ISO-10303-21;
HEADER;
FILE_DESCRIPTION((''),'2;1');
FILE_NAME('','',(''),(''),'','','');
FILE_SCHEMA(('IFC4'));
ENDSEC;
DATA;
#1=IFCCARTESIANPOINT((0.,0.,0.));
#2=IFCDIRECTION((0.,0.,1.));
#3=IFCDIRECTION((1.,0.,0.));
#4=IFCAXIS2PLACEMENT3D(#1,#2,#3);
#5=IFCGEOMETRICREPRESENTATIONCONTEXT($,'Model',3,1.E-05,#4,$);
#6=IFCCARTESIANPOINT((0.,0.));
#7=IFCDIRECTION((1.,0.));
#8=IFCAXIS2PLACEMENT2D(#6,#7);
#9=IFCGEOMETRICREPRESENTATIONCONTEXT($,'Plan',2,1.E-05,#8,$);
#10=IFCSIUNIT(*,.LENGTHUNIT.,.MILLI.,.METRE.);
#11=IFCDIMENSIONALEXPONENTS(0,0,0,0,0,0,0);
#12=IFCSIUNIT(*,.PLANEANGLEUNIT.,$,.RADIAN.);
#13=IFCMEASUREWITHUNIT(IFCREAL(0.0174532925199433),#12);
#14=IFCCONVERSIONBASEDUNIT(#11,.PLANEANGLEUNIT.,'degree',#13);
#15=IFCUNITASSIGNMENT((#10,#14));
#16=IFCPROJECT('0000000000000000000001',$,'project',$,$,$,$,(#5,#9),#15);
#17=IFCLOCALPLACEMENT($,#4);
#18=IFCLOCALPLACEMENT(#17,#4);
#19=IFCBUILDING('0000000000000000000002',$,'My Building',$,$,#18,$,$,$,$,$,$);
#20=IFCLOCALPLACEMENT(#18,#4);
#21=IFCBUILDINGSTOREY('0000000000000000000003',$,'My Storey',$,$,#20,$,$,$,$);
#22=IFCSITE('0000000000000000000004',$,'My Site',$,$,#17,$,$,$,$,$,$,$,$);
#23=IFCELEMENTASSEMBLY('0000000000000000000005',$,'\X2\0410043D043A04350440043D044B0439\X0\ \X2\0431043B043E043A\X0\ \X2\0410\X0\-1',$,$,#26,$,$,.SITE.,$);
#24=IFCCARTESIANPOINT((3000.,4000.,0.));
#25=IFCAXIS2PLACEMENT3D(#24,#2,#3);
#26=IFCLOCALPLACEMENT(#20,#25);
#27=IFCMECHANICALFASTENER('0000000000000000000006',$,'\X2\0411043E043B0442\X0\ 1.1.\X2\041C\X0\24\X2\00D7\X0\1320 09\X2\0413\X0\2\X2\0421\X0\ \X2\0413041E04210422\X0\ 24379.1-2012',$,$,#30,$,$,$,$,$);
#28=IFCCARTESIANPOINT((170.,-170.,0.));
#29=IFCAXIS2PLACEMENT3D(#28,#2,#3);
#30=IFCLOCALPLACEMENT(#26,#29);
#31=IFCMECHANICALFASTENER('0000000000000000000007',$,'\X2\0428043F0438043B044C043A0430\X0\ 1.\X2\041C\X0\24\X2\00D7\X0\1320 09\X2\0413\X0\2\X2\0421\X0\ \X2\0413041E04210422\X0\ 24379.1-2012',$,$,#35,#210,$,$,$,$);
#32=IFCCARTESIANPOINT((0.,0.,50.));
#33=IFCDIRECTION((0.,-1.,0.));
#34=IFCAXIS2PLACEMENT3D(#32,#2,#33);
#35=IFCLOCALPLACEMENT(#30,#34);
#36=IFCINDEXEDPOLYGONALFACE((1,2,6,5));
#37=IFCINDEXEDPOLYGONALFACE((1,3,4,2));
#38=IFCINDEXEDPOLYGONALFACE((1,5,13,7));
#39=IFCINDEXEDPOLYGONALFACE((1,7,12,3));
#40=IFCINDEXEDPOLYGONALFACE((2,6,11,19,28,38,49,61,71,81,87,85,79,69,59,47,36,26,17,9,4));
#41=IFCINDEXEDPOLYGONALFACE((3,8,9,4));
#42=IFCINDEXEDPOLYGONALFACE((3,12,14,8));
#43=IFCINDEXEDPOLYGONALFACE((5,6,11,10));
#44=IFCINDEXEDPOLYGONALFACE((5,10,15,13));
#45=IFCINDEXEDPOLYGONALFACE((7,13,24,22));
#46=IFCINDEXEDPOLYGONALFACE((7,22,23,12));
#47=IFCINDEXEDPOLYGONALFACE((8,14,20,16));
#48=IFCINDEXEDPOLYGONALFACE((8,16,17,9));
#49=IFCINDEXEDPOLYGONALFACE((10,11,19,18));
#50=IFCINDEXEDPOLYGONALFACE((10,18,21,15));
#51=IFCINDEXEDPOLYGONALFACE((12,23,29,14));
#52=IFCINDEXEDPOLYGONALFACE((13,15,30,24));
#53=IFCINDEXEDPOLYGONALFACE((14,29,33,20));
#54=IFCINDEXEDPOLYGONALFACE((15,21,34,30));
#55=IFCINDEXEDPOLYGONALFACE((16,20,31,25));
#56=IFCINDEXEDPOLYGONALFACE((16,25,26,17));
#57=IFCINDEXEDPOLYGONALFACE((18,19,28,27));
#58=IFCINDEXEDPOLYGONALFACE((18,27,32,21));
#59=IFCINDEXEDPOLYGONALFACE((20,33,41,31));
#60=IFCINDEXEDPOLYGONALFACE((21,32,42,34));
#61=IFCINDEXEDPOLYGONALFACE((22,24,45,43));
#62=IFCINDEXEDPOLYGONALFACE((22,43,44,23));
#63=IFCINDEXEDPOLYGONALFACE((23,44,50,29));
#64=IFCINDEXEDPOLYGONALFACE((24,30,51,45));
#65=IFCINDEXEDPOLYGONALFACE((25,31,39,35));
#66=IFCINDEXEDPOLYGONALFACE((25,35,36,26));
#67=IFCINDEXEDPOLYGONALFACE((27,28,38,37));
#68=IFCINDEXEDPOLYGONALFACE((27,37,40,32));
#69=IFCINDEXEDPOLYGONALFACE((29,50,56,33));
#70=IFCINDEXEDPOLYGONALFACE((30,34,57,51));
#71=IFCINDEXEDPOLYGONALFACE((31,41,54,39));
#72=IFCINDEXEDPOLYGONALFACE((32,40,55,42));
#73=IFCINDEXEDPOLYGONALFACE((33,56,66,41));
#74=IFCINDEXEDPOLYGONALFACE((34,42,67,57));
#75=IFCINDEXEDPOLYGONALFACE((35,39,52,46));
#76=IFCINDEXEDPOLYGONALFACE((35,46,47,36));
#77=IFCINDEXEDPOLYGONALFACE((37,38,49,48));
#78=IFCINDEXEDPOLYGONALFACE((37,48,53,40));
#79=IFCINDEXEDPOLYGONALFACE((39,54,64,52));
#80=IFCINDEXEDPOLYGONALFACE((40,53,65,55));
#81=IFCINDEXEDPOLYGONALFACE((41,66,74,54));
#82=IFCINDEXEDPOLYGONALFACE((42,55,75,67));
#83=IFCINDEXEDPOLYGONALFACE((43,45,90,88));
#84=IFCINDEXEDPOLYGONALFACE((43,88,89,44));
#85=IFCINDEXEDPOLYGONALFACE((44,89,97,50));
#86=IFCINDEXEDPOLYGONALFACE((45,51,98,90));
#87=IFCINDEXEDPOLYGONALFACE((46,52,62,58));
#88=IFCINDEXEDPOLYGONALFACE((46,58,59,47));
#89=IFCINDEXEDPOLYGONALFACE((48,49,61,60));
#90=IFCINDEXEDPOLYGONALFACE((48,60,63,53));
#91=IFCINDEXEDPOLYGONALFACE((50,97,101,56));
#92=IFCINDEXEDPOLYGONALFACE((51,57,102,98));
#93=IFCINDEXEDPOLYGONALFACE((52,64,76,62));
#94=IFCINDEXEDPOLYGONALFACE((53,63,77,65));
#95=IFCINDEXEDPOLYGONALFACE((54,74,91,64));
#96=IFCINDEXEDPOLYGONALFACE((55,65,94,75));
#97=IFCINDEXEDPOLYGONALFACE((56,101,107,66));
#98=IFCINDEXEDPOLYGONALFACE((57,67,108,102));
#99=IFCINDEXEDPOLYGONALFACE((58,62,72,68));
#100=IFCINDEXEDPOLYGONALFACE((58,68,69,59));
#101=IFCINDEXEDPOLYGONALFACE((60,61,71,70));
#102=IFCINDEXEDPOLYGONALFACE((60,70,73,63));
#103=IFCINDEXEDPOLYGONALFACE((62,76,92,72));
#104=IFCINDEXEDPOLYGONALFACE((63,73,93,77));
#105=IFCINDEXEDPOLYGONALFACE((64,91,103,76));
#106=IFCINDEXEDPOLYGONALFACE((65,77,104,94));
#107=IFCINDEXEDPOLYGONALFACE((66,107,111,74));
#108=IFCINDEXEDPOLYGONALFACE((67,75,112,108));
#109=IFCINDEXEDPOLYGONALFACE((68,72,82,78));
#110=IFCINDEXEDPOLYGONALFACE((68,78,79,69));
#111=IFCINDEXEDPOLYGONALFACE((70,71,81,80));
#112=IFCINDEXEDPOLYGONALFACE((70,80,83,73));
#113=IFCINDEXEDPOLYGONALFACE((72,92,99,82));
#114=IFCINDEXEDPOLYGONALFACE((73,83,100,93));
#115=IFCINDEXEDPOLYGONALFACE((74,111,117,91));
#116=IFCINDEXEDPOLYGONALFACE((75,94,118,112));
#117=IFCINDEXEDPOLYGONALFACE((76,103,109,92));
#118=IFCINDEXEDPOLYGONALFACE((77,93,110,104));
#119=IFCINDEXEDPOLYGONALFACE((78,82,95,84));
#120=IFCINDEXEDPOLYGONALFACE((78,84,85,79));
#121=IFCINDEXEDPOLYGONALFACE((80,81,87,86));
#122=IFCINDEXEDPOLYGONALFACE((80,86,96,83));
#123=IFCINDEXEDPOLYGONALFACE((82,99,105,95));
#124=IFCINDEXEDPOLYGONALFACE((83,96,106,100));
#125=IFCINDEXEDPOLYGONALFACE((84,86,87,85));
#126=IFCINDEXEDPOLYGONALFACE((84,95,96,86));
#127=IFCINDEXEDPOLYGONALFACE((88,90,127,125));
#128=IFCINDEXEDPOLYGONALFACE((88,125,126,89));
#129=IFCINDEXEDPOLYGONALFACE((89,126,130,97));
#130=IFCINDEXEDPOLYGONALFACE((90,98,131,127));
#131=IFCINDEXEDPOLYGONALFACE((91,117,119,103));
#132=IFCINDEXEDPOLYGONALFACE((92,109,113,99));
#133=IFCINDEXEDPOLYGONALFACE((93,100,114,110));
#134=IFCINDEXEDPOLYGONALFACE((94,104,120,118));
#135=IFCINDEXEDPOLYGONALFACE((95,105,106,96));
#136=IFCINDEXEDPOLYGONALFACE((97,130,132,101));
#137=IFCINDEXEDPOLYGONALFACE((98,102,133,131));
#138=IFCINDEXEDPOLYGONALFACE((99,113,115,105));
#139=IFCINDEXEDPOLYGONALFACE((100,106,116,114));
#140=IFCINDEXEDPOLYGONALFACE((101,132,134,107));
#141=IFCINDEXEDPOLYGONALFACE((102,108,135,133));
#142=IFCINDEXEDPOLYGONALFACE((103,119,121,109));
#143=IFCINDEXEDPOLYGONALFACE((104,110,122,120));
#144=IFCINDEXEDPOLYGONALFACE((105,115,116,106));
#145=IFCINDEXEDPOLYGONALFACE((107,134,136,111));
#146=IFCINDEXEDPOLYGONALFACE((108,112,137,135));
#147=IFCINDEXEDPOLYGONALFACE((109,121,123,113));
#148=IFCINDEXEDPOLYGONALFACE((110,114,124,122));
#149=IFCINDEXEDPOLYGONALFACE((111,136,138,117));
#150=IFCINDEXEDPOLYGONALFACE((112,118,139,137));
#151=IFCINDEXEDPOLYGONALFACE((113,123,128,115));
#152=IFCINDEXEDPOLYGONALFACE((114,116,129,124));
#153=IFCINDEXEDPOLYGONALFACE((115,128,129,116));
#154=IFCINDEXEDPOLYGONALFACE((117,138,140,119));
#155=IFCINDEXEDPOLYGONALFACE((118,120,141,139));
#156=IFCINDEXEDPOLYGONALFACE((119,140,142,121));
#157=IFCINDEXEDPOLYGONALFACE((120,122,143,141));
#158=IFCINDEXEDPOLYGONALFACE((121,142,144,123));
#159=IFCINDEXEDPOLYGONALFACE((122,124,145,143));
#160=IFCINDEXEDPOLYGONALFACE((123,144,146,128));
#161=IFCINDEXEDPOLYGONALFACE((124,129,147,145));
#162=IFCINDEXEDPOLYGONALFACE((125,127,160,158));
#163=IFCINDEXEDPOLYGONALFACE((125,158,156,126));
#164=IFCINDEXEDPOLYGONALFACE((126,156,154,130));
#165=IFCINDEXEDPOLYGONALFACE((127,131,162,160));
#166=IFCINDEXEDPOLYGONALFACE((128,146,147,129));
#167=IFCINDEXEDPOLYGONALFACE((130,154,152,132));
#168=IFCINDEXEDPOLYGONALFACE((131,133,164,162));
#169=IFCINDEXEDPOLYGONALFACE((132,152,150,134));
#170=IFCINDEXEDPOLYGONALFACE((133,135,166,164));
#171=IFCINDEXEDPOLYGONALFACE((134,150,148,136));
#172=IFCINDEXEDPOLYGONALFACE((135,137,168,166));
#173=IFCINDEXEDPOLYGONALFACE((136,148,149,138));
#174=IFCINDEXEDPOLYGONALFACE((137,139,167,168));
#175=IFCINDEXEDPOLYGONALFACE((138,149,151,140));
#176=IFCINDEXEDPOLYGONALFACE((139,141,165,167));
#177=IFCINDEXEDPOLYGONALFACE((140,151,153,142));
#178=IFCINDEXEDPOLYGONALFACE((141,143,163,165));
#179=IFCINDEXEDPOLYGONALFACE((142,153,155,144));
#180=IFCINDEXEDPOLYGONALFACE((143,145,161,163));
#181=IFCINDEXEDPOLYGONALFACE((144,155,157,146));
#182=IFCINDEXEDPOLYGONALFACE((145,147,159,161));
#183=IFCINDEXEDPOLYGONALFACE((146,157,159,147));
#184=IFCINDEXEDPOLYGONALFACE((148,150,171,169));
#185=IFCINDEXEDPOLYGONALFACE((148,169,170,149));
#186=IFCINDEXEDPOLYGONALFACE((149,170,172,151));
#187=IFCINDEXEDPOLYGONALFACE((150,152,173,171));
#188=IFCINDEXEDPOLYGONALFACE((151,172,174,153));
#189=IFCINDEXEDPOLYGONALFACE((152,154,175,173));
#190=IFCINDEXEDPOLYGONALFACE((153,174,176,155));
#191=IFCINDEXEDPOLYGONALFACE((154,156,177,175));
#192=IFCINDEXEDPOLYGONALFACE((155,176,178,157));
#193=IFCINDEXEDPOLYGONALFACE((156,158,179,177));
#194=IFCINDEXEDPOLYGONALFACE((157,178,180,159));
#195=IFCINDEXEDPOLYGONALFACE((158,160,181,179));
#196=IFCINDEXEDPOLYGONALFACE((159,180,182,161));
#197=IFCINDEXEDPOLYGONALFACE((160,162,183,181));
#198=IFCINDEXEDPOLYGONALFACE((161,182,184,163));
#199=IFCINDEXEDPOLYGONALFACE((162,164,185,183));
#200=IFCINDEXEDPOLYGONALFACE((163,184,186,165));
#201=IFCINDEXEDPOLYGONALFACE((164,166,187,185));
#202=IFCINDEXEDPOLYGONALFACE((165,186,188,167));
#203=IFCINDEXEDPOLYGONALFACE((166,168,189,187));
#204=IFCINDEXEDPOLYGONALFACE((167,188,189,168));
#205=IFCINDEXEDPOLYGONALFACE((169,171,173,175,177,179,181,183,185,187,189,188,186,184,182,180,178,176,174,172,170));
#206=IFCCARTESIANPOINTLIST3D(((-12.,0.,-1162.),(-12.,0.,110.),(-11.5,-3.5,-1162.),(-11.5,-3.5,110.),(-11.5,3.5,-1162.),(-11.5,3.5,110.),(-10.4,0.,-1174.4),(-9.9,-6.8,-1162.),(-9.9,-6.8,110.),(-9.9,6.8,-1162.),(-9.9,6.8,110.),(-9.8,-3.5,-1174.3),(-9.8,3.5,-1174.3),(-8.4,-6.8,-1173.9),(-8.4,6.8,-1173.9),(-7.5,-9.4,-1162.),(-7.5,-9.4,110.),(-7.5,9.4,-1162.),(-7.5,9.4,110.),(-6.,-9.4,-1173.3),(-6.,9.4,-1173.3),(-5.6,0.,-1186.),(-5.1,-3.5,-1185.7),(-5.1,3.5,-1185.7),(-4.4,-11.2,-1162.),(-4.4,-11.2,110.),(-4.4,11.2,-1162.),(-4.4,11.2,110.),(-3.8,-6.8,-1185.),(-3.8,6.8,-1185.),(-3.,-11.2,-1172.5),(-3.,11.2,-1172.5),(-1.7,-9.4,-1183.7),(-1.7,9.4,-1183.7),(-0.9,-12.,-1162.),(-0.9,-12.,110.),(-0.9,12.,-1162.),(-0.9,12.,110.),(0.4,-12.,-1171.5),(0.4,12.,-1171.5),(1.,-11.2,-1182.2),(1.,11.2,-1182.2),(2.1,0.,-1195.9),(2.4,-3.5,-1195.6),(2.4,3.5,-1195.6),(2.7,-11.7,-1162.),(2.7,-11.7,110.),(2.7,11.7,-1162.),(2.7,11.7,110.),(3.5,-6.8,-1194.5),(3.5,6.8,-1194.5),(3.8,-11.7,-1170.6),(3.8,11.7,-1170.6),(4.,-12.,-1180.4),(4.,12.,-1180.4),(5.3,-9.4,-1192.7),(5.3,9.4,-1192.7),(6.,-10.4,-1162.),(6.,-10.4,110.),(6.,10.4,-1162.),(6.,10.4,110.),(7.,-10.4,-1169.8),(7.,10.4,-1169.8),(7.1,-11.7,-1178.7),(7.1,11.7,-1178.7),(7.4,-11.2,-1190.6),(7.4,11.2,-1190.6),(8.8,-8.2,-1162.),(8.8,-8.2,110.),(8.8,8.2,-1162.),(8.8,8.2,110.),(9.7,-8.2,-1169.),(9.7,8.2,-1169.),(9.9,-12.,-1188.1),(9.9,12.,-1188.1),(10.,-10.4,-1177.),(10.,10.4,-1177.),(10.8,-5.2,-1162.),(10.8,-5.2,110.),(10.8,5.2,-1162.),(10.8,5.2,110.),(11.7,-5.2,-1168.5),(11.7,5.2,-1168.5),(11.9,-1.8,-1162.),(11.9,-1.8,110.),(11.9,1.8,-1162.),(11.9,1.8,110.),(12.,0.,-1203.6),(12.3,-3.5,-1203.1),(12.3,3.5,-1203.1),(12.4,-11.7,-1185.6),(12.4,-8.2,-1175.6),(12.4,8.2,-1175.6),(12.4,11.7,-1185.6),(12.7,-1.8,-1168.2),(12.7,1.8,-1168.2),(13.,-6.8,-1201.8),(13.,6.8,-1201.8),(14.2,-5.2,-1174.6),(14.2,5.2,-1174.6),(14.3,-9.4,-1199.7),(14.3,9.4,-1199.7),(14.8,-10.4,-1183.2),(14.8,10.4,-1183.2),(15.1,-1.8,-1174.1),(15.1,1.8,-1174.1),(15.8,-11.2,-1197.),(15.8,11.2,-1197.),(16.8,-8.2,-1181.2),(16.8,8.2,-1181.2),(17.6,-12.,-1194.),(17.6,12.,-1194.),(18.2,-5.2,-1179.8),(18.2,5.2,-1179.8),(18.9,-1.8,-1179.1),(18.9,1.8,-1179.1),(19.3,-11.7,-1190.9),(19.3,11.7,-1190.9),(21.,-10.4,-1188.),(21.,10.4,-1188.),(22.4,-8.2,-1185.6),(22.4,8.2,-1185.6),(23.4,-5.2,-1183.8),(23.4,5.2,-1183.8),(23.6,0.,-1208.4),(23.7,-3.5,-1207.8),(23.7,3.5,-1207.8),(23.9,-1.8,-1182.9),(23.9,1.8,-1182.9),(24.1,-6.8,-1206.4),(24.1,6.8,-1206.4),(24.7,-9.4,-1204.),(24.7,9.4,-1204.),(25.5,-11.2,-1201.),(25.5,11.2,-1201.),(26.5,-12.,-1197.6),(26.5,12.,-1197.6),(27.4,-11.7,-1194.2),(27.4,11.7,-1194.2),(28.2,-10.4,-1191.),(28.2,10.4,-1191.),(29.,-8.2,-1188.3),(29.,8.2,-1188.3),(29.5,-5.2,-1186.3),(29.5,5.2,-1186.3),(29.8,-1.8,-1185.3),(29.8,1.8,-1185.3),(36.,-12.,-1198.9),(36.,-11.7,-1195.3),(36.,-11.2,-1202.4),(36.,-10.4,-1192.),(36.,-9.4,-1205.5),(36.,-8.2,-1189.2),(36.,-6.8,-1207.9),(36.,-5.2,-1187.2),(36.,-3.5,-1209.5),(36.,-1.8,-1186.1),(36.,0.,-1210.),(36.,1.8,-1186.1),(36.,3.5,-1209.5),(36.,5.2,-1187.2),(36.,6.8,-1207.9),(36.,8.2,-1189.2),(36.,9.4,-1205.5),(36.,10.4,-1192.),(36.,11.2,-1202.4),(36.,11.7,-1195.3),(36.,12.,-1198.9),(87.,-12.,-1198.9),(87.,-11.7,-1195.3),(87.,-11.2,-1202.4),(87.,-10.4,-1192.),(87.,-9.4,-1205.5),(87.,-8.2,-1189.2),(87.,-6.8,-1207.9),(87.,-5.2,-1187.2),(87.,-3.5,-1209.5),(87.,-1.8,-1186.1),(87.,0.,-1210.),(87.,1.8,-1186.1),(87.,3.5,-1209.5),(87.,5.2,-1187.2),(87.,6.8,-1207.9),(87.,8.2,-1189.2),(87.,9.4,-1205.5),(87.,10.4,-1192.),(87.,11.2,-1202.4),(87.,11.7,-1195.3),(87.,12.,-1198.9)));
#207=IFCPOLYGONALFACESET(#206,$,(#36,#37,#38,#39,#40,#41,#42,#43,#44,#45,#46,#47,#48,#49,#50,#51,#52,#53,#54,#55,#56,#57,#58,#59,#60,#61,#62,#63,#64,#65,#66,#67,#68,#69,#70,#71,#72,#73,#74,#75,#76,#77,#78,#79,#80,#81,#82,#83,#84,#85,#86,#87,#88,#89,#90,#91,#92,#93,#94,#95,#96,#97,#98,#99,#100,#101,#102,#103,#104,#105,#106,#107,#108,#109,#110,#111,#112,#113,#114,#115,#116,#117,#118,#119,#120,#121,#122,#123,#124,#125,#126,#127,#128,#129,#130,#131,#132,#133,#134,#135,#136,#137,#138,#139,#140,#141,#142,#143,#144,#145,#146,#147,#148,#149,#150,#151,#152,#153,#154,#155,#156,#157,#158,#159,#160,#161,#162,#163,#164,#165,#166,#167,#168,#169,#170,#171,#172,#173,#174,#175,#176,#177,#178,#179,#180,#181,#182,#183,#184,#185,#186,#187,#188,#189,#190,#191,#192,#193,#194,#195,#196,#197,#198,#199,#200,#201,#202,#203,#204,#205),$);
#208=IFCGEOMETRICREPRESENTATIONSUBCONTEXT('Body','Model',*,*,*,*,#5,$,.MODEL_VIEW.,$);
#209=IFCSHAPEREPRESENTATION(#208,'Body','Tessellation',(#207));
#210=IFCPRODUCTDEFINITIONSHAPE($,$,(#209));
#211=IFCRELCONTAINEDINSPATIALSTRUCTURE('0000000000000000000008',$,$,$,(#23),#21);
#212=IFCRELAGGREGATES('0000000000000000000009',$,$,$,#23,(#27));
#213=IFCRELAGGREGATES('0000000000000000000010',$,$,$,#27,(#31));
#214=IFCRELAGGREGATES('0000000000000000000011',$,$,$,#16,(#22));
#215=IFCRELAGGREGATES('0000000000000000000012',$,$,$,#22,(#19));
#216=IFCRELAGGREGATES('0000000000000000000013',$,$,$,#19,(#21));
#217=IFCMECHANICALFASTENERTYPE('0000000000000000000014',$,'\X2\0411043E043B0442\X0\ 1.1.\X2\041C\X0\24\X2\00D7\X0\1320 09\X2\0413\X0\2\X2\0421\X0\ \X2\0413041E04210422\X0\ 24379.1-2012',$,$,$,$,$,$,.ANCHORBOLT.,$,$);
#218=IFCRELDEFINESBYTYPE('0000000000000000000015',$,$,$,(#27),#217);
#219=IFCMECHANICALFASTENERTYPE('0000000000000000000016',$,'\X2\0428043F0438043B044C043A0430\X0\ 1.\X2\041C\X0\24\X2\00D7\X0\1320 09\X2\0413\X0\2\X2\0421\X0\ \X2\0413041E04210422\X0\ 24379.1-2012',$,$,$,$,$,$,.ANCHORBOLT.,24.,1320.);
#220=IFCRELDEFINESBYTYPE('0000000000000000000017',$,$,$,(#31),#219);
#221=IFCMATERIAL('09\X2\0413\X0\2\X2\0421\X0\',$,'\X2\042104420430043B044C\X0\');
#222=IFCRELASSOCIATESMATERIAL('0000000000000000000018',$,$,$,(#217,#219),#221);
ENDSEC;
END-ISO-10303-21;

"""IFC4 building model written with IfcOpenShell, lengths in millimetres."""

from ifc_helpers import new_model, entity, si_unit, converted_unit, frame, origin_with_axes, origin_2d_with_axis, place, context, subcontext, project, spatial, source, transform, mapped, material, type_object, type_shapes, element, aggregate, save


model = new_model("IFC4")

# Units and contexts
model_context = context("Model", 3, precision=1e-05, world=origin_with_axes())
plan_context = context("Plan", 2, precision=1e-05, world=origin_2d_with_axis())
body_context = subcontext(model_context, "Body", "Model", "MODEL_VIEW")
ifc_project = project(units=[si_unit("LENGTHUNIT", "METRE", prefix="MILLI"), converted_unit("PLANEANGLEUNIT", "degree", entity("IfcReal", 0.0174532925199433), si_unit("PLANEANGLEUNIT", "RADIAN"), dimensions=[0, 0, 0, 0, 0, 0, 0])], contexts=[model_context, plan_context])

# Site, building, storey
site_placement = place(None, origin_with_axes())
site = spatial("IfcSite", under=ifc_project, at=site_placement, Name="My Site")
building_placement = place(site_placement, origin_with_axes())
building = spatial("IfcBuilding", under=site, at=building_placement, Name="My Building")
storey_placement = place(building_placement, origin_with_axes())
storey = spatial("IfcBuildingStorey", under=building, at=storey_placement, Name="My Storey")

# Element assembly, mechanical fasteners
ifc_material_1 = material(Name="09Г2С", Category="Сталь")
mechanical_fastener_type_1 = type_object("IfcMechanicalFastenerType", Name="Болт 1.1.М24×1320 09Г2С ГОСТ 24379.1-2012", PredefinedType="ANCHORBOLT", material=ifc_material_1)
mechanical_fastener_type_2 = type_object("IfcMechanicalFastenerType", Name="Шпилька 1.М24×1320 09Г2С ГОСТ 24379.1-2012", NominalDiameter=24.0, NominalLength=1320.0, PredefinedType="ANCHORBOLT", material=ifc_material_1)
shared_shape_1 = source(frame((0.0, 0.0, 110.0), z_axis=(0.0, 0.0, 1.0), x_axis=(1.0, 0.0, 0.0)), body_context, "Body", "AdvancedSweptSolid", [
    entity("IfcSweptDiskSolid", entity("IfcIndexedPolyCurve", entity("IfcCartesianPointList3D", [[0.0, 0.0, 0.0], [0.0, 0.0, -1272.0], [10.5, 0.0, -1297.5], [36.0, 0.0, -1308.0], [87.0, 0.0, -1308.0]]), [entity("IfcLineIndex", [1, 2]), entity("IfcArcIndex", [2, 3, 4]), entity("IfcLineIndex", [4, 5])]), 12.0),
])
type_shapes(mechanical_fastener_type_2, [shared_shape_1])
assembly_1_placement = place(storey_placement, frame((3000.0, 4000.0, 0.0), z_axis=(0.0, 0.0, 1.0), x_axis=(1.0, 0.0, 0.0)))
assembly_1 = element("IfcElementAssembly", 1, at=assembly_1_placement, inside=storey, Name="Анкерный блок А-1", AssemblyPlace="SITE")
mechanical_fastener_1_placement = place(assembly_1_placement, frame((170.0, -170.0, 0.0), z_axis=(0.0, 0.0, 1.0), x_axis=(1.0, 0.0, 0.0)))
mechanical_fastener_1 = element("IfcMechanicalFastener", 2, at=mechanical_fastener_1_placement, type_object=mechanical_fastener_type_1, Name="Болт 1.1.М24×1320 09Г2С ГОСТ 24379.1-2012")
aggregate(assembly_1, [mechanical_fastener_1])
mechanical_fastener_2_placement = place(mechanical_fastener_1_placement, frame((0.0, 0.0, 50.0), z_axis=(0.0, 0.0, 1.0), x_axis=(0.0, -1.0, 0.0)))
mechanical_fastener_2 = element("IfcMechanicalFastener", 3, at=mechanical_fastener_2_placement, type_object=mechanical_fastener_type_2, Name="Шпилька 1.М24×1320 09Г2С ГОСТ 24379.1-2012", context=body_context, shape_type="MappedRepresentation", body=[
    mapped(shared_shape_1, transform((0.0, 0.0, 0.0), x_axis=(1.0, 0.0, 0.0), y_axis=(0.0, 1.0, 0.0), z_axis=(0.0, 0.0, 1.0), scale=1.0)),
])

aggregate(mechanical_fastener_1, [mechanical_fastener_2])

save(model, "model.ifc")
